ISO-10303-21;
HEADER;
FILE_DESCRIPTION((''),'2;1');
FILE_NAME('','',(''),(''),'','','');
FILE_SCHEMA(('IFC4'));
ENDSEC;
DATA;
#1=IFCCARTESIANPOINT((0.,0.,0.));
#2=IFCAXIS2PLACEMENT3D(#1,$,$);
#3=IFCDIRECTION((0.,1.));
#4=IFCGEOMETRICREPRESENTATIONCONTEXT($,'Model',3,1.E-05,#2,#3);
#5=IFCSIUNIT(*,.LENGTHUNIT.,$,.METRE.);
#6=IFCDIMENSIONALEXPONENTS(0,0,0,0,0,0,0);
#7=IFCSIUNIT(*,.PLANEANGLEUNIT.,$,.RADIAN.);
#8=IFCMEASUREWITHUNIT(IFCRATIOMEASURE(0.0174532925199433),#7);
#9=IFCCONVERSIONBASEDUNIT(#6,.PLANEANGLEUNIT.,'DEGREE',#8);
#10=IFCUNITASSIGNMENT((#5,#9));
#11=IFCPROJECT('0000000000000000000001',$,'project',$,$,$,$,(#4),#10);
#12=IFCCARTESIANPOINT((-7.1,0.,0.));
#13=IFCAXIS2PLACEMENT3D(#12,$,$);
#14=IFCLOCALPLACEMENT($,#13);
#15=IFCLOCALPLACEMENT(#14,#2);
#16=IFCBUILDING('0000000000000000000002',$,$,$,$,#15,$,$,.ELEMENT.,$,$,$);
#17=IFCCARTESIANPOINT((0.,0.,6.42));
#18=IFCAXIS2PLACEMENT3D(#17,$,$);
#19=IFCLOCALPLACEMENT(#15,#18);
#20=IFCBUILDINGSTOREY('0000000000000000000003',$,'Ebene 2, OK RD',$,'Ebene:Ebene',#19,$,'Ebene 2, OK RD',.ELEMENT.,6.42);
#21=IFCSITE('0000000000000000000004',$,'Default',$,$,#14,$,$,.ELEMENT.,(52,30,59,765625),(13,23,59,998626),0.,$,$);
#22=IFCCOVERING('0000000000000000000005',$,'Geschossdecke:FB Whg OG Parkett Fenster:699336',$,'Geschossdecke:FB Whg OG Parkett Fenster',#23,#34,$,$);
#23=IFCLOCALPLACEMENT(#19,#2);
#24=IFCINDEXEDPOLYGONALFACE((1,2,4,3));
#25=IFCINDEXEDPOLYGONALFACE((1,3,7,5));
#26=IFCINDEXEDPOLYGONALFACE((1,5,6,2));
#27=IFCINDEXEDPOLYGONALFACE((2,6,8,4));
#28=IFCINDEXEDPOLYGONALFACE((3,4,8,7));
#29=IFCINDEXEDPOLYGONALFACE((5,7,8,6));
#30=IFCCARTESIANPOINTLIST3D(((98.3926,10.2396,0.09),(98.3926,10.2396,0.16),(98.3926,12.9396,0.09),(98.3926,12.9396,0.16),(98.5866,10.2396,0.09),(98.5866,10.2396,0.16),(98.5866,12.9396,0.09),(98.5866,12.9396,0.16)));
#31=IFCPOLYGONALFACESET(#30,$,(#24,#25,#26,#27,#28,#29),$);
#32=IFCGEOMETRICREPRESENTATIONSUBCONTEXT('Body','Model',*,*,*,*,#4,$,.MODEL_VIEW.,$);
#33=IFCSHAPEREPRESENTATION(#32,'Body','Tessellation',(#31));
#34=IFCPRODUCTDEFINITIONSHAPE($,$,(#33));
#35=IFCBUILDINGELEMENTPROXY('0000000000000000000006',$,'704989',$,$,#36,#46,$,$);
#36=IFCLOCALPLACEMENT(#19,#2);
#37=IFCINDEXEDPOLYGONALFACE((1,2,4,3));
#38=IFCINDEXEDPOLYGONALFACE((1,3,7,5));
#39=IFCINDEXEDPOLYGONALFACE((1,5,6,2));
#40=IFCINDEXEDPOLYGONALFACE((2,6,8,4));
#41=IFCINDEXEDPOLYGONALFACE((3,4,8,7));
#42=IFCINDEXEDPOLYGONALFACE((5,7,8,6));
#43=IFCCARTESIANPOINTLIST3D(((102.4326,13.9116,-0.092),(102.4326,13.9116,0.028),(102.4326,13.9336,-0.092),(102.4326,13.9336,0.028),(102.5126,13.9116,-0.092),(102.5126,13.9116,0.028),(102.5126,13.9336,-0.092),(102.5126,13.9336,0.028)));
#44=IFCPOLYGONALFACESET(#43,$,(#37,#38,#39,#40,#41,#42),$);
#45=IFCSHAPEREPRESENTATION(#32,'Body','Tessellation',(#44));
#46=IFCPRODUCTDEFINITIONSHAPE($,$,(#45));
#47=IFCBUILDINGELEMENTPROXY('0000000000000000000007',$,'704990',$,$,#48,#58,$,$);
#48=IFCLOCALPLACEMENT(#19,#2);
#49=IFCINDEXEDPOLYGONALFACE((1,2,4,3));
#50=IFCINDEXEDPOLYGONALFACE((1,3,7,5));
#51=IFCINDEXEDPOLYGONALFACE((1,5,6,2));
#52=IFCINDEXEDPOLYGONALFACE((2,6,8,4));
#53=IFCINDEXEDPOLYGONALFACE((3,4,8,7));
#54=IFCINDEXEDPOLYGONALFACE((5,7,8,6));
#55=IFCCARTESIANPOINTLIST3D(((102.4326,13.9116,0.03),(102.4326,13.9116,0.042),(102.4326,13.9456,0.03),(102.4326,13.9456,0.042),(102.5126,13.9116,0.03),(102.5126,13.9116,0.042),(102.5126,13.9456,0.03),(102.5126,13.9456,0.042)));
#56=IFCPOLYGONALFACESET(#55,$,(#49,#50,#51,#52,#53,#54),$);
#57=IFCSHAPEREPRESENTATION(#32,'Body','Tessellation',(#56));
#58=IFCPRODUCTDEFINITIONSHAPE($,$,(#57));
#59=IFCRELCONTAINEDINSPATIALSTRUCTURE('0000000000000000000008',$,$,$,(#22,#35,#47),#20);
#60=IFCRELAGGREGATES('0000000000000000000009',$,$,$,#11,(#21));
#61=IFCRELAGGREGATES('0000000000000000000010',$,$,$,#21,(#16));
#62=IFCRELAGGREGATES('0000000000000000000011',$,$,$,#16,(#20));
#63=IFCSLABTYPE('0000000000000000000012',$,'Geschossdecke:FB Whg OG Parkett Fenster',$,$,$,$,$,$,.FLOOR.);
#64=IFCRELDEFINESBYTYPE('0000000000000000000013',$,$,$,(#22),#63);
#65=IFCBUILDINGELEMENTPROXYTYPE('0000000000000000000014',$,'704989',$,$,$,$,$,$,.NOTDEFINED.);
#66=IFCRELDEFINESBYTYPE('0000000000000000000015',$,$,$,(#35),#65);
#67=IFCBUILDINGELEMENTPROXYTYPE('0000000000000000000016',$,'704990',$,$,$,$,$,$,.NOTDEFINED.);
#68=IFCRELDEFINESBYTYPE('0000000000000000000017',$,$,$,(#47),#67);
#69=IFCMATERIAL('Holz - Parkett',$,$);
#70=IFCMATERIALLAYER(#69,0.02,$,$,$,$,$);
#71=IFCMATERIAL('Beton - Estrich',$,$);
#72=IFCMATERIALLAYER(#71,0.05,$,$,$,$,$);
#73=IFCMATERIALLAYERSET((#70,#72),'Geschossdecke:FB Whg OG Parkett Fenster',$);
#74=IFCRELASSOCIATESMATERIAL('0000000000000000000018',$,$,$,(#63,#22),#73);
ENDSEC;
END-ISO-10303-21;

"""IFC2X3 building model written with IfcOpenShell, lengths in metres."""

from ifc_helpers import new_model, entity, si_unit, converted_unit, direction, frame, frame_2d, origin, place, context, subcontext, project, spatial, rectangle, extrude, material, layer, layer_set, layer_usage, type_object, element, save


model = new_model("IFC2X3")

# Units and contexts
model_context = context("Model", 3, precision=1e-05, world=origin(), true_north=direction((0.0, 1.0)))
body_context = subcontext(model_context, "Body", "Model", "MODEL_VIEW")
ifc_project = project(units=[si_unit("LENGTHUNIT", "METRE"), converted_unit("PLANEANGLEUNIT", "DEGREE", entity("IfcRatioMeasure", 0.0174532925199433), si_unit("PLANEANGLEUNIT", "RADIAN"), dimensions=[0, 0, 0, 0, 0, 0, 0])], contexts=[model_context])

# Site, building, storey
site_placement = place(None, frame((-7.1, 0.0, 0.0)))
site = spatial("IfcSite", under=ifc_project, at=site_placement, Name="Default", CompositionType="ELEMENT", RefLatitude=(52, 30, 59, 765625), RefLongitude=(13, 23, 59, 998626), RefElevation=0.0)
building_placement = place(site_placement, origin())
building = spatial("IfcBuilding", under=site, at=building_placement, CompositionType="ELEMENT")
storey_placement = place(building_placement, frame((0.0, 0.0, 6.42)))
storey = spatial("IfcBuildingStorey", under=building, at=storey_placement, Name="Ebene 2, OK RD", ObjectType="Ebene:Ebene", LongName="Ebene 2, OK RD", CompositionType="ELEMENT", Elevation=6.42)

# Covering
ifc_material_1 = material(Name="Holz - Parkett")
ifc_layer_1 = layer(ifc_material_1, 0.02)
ifc_material_2 = material(Name="Beton - Estrich")
ifc_layer_2 = layer(ifc_material_2, 0.05)
ifc_layer_set_1 = layer_set([ifc_layer_1, ifc_layer_2], Name="Geschossdecke:FB Whg OG Parkett Fenster")
ifc_layer_usage_1 = layer_usage(ifc_layer_set_1, "AXIS3", "POSITIVE", 0.0)
slab_type_1 = type_object("IfcSlabType", Name="Geschossdecke:FB Whg OG Parkett Fenster", PredefinedType="FLOOR", material=ifc_layer_set_1)
covering_1_placement = place(storey_placement, origin())
element("IfcCovering", 1, at=covering_1_placement, inside=storey, type_object=slab_type_1, material=ifc_layer_usage_1, Name="Geschossdecke:FB Whg OG Parkett Fenster:699336", ObjectType="Geschossdecke:FB Whg OG Parkett Fenster", context=body_context, shape_type="SweptSolid", body=[
    extrude(rectangle(XDim=2.7, YDim=0.194, at=frame_2d((0.0, 0.0), x_axis=(1.0, 0.0))), frame((98.4896, 11.5896, 0.16), z_axis=(0.0, 0.0, -1.0), x_axis=(0.0, 1.0, 0.0)), (0.0, 0.0, 1.0), 0.07),
])

# Building element proxies
building_element_proxy_type_1 = type_object("IfcBuildingElementProxyType", Name="704989", PredefinedType="NOTDEFINED")
proxy_1_placement = place(storey_placement, origin())
element("IfcBuildingElementProxy", 2, at=proxy_1_placement, inside=storey, type_object=building_element_proxy_type_1, Name="704989", context=body_context, shape_type="SweptSolid", body=[
    extrude(rectangle(XDim=0.08, YDim=0.022, at=frame_2d((0.0, 0.0), x_axis=(1.0, 0.0))), frame((102.4726, 13.9226, -0.092)), (0.0, 0.0, 1.0), 0.12),
])
building_element_proxy_type_2 = type_object("IfcBuildingElementProxyType", Name="704990", PredefinedType="NOTDEFINED")
proxy_2_placement = place(storey_placement, origin())
element("IfcBuildingElementProxy", 3, at=proxy_2_placement, inside=storey, type_object=building_element_proxy_type_2, Name="704990", context=body_context, shape_type="SweptSolid", body=[
    extrude(rectangle(XDim=0.08, YDim=0.034, at=frame_2d((0.0, 0.0), x_axis=(1.0, 0.0))), frame((102.4726, 13.9286, 0.03)), (0.0, 0.0, 1.0), 0.012),
])

save(model, "model.ifc")
